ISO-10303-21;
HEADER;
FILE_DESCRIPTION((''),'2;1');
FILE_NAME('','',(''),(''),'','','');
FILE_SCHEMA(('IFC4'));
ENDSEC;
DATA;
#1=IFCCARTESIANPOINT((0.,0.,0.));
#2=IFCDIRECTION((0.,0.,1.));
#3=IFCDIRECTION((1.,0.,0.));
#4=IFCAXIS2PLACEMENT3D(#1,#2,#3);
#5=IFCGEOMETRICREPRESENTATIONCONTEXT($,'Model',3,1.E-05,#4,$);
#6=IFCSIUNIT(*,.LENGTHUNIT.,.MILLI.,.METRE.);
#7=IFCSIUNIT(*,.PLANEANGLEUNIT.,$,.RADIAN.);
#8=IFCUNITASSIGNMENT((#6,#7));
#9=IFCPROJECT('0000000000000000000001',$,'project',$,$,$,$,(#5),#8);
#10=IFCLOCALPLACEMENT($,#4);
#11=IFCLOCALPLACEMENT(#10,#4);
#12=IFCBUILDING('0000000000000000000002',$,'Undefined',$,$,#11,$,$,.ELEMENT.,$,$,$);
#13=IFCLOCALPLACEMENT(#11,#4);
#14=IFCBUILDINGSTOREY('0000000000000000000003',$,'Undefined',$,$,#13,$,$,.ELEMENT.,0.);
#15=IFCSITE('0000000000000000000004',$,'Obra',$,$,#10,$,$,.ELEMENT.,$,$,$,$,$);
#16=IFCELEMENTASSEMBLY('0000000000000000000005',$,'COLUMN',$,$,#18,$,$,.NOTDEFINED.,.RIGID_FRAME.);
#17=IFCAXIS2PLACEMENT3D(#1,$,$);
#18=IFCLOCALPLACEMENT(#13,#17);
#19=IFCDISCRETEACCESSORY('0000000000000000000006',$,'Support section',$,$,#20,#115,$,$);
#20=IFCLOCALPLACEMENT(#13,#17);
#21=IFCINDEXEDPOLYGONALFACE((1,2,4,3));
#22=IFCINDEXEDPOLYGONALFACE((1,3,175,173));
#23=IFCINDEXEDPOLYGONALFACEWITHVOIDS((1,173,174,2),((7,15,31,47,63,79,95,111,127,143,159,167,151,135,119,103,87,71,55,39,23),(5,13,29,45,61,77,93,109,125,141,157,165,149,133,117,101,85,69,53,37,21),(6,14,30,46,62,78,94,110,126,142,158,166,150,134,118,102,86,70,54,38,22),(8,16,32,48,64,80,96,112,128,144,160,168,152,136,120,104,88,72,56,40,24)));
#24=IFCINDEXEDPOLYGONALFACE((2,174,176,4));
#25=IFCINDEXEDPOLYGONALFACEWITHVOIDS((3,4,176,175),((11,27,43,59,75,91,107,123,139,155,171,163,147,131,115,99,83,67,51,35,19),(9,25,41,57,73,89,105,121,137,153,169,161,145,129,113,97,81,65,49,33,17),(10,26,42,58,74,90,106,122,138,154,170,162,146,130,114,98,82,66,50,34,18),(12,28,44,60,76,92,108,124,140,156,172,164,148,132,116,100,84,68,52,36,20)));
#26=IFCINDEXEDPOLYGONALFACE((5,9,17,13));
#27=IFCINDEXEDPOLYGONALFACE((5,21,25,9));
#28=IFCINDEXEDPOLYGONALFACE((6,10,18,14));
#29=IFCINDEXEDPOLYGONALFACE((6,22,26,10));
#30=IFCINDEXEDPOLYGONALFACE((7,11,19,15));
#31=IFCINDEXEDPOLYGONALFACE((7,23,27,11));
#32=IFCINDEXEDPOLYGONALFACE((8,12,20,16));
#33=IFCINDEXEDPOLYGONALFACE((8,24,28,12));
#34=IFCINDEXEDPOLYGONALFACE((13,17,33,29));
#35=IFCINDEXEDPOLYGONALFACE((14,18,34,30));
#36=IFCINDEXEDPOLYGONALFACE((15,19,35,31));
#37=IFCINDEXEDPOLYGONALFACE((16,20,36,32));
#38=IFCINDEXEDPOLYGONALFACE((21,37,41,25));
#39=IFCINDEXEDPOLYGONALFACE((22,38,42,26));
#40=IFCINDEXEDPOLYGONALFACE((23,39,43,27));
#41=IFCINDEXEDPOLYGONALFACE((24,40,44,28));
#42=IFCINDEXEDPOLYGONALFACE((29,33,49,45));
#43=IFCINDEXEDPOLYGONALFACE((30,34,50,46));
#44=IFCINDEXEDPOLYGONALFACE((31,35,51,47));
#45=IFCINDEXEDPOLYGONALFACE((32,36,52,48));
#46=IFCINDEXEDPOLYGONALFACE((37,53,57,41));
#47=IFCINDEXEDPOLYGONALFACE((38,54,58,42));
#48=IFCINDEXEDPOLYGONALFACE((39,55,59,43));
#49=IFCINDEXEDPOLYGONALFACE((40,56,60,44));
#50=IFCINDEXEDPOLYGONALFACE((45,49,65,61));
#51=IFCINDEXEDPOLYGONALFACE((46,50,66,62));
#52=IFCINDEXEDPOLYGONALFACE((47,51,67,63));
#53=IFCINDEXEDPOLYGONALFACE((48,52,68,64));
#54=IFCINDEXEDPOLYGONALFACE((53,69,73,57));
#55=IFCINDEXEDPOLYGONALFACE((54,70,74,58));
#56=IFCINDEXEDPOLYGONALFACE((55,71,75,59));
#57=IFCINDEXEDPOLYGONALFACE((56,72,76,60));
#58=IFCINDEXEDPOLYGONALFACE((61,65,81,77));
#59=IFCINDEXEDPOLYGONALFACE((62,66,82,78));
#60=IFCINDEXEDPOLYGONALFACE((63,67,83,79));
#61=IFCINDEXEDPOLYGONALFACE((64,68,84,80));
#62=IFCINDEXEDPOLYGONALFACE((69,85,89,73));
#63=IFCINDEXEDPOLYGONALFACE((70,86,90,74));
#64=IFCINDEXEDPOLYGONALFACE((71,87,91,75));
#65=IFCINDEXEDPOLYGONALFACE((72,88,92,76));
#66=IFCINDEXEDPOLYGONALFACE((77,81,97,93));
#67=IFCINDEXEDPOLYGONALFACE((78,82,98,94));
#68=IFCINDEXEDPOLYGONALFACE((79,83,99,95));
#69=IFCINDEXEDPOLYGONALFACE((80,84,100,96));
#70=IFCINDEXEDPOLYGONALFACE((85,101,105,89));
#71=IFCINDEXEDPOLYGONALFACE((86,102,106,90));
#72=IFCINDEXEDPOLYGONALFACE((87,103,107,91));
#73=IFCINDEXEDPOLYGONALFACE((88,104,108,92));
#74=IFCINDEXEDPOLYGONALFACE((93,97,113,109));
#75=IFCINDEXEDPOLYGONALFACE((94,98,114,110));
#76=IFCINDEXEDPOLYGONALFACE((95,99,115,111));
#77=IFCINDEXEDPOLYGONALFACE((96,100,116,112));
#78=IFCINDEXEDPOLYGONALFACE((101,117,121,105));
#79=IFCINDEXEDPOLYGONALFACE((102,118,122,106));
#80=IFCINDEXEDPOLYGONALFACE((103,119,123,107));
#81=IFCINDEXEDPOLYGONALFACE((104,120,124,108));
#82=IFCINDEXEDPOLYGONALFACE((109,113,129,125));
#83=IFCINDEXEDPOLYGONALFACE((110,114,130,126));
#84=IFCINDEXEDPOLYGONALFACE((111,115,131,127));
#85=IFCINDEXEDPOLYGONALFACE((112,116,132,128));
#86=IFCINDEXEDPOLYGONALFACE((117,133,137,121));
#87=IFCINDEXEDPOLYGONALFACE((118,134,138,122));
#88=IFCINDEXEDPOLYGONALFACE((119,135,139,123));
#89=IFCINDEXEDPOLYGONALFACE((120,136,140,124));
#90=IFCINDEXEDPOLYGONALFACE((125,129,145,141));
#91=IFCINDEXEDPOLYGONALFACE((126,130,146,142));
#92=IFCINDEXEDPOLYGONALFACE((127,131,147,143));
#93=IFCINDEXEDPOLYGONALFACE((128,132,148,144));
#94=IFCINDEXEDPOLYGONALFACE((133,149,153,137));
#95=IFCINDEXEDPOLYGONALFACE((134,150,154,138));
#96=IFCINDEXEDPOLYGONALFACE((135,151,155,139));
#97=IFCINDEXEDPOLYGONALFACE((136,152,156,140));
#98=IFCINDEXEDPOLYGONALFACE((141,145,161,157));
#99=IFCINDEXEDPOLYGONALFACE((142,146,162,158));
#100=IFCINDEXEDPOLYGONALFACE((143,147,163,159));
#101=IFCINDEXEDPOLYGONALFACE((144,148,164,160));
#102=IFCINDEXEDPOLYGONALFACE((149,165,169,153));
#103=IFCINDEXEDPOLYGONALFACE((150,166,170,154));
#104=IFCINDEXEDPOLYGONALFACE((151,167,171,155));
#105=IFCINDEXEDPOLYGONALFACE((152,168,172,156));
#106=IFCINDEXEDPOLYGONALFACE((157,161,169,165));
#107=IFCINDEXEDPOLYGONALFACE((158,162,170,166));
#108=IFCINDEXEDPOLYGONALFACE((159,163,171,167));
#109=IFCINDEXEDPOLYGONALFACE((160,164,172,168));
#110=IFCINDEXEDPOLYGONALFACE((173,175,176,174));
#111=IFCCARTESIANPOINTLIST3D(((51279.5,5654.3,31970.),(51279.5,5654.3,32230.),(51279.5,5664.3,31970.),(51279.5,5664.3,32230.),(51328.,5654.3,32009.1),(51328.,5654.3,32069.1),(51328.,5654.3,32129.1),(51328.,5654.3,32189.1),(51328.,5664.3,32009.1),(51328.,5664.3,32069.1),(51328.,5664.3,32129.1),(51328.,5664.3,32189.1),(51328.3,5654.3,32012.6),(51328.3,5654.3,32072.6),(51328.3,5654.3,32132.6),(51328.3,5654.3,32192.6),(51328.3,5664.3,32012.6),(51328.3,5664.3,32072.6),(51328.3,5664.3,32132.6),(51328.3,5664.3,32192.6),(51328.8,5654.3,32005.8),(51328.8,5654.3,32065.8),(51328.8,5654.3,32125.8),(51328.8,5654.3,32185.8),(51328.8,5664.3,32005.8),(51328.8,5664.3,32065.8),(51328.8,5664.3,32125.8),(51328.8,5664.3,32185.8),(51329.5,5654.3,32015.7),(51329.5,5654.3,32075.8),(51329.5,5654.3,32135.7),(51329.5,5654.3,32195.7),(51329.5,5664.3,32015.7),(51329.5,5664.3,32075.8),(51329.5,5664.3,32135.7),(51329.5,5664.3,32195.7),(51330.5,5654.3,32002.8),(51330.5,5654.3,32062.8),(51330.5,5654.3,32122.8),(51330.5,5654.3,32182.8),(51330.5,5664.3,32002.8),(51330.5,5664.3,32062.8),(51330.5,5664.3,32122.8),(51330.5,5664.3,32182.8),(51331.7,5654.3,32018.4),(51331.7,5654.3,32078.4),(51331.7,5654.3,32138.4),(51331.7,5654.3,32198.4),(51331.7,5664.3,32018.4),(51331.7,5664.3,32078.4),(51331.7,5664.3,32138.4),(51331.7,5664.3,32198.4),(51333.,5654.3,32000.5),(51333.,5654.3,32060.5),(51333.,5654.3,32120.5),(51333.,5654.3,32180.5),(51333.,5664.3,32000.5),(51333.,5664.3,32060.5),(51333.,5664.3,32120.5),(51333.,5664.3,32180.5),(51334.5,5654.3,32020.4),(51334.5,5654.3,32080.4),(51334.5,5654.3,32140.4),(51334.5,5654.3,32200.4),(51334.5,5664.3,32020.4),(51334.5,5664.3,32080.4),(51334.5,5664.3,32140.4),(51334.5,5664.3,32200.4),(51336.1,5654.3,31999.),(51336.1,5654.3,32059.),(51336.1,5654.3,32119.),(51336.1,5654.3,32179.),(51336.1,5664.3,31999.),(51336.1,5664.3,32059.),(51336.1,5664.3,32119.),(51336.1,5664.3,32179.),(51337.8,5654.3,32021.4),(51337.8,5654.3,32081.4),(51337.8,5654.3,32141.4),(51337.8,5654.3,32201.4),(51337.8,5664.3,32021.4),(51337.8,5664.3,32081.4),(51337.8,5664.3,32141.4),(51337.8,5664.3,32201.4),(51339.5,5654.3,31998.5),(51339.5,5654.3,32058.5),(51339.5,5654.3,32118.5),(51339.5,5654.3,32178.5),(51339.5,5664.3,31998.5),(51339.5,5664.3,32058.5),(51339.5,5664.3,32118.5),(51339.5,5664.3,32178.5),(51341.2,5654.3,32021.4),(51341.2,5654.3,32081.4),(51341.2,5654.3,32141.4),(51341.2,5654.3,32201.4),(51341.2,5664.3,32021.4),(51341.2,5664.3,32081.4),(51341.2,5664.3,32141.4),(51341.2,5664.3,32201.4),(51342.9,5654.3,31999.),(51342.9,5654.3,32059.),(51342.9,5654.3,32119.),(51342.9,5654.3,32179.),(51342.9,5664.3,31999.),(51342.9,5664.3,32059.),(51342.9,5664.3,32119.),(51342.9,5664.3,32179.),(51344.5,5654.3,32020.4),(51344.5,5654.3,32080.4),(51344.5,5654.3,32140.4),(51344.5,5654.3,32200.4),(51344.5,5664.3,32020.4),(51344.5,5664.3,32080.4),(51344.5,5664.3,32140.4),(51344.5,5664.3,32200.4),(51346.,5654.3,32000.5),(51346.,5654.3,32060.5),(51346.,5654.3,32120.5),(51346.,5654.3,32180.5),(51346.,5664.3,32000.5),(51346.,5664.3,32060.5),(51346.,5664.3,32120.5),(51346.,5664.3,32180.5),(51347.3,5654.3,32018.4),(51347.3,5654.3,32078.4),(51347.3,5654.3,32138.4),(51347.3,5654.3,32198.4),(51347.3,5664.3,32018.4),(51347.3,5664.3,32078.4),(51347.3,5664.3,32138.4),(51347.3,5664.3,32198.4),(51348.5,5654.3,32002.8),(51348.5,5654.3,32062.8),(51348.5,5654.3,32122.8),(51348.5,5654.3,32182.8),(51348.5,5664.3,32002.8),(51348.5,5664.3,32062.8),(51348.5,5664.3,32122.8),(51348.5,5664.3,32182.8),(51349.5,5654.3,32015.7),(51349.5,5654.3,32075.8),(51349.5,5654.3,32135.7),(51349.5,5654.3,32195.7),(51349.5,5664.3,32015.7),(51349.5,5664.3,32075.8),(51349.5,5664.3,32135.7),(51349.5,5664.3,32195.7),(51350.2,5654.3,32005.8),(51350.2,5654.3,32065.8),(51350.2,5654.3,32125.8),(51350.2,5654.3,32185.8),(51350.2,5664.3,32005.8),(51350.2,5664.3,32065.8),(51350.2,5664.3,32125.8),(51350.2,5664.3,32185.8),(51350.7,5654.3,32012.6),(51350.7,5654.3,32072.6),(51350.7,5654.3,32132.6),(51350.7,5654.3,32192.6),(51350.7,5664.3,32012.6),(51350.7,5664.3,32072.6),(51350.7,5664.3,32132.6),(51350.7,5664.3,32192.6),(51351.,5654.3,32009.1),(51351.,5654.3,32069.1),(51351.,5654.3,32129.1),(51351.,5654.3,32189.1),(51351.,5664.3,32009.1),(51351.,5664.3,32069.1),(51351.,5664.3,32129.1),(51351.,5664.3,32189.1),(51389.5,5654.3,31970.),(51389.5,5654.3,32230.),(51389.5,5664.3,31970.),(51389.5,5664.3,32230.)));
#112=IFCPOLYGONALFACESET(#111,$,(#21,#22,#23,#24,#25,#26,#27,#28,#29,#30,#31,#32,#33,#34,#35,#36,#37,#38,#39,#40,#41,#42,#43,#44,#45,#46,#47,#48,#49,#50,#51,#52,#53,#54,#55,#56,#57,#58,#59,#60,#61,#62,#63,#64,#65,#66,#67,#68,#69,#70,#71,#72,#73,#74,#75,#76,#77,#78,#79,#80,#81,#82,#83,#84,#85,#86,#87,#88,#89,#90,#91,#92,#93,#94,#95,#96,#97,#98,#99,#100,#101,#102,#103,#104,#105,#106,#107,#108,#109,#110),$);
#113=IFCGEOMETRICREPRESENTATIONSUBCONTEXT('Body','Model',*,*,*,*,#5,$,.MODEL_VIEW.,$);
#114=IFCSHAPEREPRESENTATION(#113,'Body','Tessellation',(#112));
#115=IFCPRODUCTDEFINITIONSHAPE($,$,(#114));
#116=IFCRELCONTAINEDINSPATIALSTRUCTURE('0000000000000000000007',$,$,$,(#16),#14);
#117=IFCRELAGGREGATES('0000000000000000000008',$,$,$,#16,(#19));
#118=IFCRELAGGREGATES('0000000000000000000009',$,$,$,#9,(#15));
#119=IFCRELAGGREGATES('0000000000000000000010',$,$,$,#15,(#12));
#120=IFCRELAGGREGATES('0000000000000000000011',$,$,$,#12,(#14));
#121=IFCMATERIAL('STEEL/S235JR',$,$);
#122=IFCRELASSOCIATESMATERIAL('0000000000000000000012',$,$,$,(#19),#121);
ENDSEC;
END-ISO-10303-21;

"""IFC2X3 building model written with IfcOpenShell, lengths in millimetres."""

from ifc_helpers import new_model, si_unit, frame, origin_with_axes, origin_2d_with_axis, place, context, subcontext, project, spatial, rectangle, circle, extrude, source, transform, mapped, material, element, aggregate, save


model = new_model("IFC2X3")

# Units and contexts
model_context = context("Model", 3, precision=1e-05, world=origin_with_axes())
body_context = subcontext(model_context, "Body", "Model", "MODEL_VIEW")
ifc_project = project(units=[si_unit("LENGTHUNIT", "METRE", prefix="MILLI"), si_unit("PLANEANGLEUNIT", "RADIAN")], contexts=[model_context])

# Site, building, storey
site_placement = place(None, origin_with_axes())
site = spatial("IfcSite", under=ifc_project, at=site_placement, Name="Obra", CompositionType="ELEMENT")
building_placement = place(site_placement, origin_with_axes())
building = spatial("IfcBuilding", under=site, at=building_placement, Name="Undefined", CompositionType="ELEMENT")
storey_placement = place(building_placement, origin_with_axes())
storey = spatial("IfcBuildingStorey", under=building, at=storey_placement, Name="Undefined", CompositionType="ELEMENT", Elevation=0.0)

# Shared definitions
ifc_material_1 = material(Name="STEEL/S235JR")

# Shared definitions
shared_shape_1 = source(origin_with_axes(), body_context, "Body", "SweptSolid", [
    extrude(circle(Radius=11.5, at=origin_2d_with_axis()), frame((0.0, -14.4, 0.0), z_axis=(0.0, 1.0, 0.0), x_axis=(1.0, 0.0, 0.0)), (0.0, 0.0, 1.0), 10.2),
])

# Element assembly, discrete accessory, opening
assembly_1_placement = place(storey_placement, origin_with_axes())
assembly_1 = element("IfcElementAssembly", 1, at=assembly_1_placement, inside=storey, Name="COLUMN", AssemblyPlace="NOTDEFINED", PredefinedType="RIGID_FRAME")
discrete_accessory_1_placement = place(assembly_1_placement, frame((51334.5, 5659.3, 31970.0), z_axis=(0.0, 0.0, 1.0), x_axis=(-1.0, 0.0, 0.0)))
discrete_accessory_1 = element("IfcDiscreteAccessory", 2, at=discrete_accessory_1_placement, material=ifc_material_1, Name="Support section", context=body_context, shape_type="SweptSolid", body=[
    extrude(rectangle(XDim=10.0, YDim=110.0, at=origin_2d_with_axis()), frame((0.0, 0.0, 260.0), z_axis=(0.0, 0.0, -1.0), x_axis=(0.0, 1.0, 0.0)), (0.0, 0.0, 1.0), 260.0),
])
opening_1_placement = place(assembly_1_placement, frame((51289.5, 5668.6, 32300.0), z_axis=(1.0, 0.0, 0.0), x_axis=(0.0, 0.0, -1.0)))
element("IfcOpeningElement", 3, at=opening_1_placement, cuts=discrete_accessory_1, ObjectType="Opening", context=body_context, shape_type="MappedRepresentation", body=[
    mapped(shared_shape_1, transform((110.0, 0.0, 50.0))),
    mapped(shared_shape_1, transform((170.0, 0.0, 50.0))),
    mapped(shared_shape_1, transform((230.0, 0.0, 50.0))),
    mapped(shared_shape_1, transform((290.0, 0.0, 50.0))),
])
aggregate(assembly_1, [discrete_accessory_1])

save(model, "model.ifc")
